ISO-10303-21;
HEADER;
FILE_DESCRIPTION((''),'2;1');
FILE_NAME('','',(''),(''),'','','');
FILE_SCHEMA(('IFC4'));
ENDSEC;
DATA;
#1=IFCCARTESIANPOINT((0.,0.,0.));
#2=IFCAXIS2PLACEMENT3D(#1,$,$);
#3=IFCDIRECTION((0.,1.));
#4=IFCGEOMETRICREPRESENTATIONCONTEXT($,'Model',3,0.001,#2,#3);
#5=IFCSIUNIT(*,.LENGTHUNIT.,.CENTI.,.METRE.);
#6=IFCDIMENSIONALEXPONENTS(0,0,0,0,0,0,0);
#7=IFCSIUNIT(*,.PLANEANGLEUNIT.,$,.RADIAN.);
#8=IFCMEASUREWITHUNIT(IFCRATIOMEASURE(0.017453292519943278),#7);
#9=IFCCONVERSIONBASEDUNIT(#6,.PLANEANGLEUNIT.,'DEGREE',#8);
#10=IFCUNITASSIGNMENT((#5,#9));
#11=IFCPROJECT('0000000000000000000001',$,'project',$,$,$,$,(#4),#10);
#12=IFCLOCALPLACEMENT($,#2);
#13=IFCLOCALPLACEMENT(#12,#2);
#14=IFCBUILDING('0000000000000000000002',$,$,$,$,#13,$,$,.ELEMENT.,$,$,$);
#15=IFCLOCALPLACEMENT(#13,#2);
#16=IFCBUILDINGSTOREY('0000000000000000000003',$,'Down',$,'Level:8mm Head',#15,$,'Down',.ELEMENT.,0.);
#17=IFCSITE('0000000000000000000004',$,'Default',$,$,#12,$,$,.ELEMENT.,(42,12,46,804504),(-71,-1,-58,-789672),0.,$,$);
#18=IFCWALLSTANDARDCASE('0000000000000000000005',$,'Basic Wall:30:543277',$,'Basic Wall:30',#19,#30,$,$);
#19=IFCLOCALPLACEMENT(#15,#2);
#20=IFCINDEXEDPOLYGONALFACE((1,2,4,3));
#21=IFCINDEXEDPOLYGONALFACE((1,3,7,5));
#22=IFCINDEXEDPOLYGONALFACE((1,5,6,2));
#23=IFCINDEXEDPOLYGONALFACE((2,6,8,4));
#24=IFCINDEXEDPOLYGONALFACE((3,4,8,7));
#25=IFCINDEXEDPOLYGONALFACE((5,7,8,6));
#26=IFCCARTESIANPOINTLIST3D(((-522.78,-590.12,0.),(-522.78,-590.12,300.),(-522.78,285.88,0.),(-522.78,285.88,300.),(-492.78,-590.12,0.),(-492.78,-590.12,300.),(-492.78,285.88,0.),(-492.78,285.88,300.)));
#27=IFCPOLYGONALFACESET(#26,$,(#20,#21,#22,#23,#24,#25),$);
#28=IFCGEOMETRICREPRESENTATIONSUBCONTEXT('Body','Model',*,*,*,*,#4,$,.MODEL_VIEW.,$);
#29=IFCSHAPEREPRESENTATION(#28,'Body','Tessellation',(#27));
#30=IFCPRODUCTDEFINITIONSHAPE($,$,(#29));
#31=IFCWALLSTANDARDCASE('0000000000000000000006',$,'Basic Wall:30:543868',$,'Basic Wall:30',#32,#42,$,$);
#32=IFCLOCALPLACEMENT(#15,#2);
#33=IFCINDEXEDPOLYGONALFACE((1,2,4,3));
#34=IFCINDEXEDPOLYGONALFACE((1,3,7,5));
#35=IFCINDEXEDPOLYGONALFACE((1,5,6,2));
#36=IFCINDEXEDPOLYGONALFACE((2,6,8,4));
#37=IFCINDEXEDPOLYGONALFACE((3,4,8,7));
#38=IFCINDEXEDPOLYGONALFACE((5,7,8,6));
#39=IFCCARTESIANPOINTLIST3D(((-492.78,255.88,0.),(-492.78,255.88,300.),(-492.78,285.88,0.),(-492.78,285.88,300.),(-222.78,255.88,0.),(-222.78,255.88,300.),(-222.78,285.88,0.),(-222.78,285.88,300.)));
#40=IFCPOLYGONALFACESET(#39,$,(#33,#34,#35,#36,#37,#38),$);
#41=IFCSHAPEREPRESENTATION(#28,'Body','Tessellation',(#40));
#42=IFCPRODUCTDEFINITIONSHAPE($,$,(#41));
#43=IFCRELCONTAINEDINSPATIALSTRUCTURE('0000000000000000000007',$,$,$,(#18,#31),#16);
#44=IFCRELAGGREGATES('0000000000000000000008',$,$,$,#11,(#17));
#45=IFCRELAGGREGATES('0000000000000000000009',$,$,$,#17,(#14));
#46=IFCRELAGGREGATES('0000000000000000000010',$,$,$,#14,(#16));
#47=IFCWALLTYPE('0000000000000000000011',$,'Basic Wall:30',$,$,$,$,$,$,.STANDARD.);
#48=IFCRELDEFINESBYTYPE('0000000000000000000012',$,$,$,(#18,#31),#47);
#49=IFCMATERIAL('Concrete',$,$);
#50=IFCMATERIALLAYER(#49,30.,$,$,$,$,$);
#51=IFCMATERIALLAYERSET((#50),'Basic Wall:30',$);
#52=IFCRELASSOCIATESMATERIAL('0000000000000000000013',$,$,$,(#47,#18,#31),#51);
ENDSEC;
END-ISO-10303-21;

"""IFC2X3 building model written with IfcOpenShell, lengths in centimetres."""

from ifc_helpers import new_model, entity, si_unit, converted_unit, direction, frame, frame_2d, origin, place, context, subcontext, project, spatial, rectangle, extrude, material, layer, layer_set, layer_usage, type_object, element, save


model = new_model("IFC2X3")

# Units and contexts
model_context = context("Model", 3, precision=0.001, world=origin(), true_north=direction((0.0, 1.0)))
body_context = subcontext(model_context, "Body", "Model", "MODEL_VIEW")
ifc_project = project(units=[si_unit("LENGTHUNIT", "METRE", prefix="CENTI"), converted_unit("PLANEANGLEUNIT", "DEGREE", entity("IfcRatioMeasure", 0.017453292519943278), si_unit("PLANEANGLEUNIT", "RADIAN"), dimensions=[0, 0, 0, 0, 0, 0, 0])], contexts=[model_context])

# Site, building, storey
site_placement = place(None, origin())
site = spatial("IfcSite", under=ifc_project, at=site_placement, Name="Default", CompositionType="ELEMENT", RefLatitude=(42, 12, 46, 804504), RefLongitude=(-71, -1, -58, -789672), RefElevation=0.0)
building_placement = place(site_placement, origin())
building = spatial("IfcBuilding", under=site, at=building_placement, CompositionType="ELEMENT")
storey_placement = place(building_placement, origin())
storey = spatial("IfcBuildingStorey", under=building, at=storey_placement, Name="Down", ObjectType="Level:8mm Head", LongName="Down", CompositionType="ELEMENT", Elevation=0.0)

# Shared definitions
ifc_material = material(Name="Concrete")

# Walls
ifc_layer_1 = layer(ifc_material, 30.0)
ifc_layer_set_1 = layer_set([ifc_layer_1], Name="Basic Wall:30")
ifc_layer_usage_1 = layer_usage(ifc_layer_set_1, "AXIS2", "POSITIVE", -15.0)
wall_type_1 = type_object("IfcWallType", Name="Basic Wall:30", PredefinedType="STANDARD", material=ifc_layer_set_1)
wall_1_placement = place(storey_placement, frame((-507.78, 285.88, 0.0), z_axis=(0.0, 0.0, 1.0), x_axis=(0.0, -1.0, 0.0)))
element("IfcWallStandardCase", 1, at=wall_1_placement, inside=storey, type_object=wall_type_1, material=ifc_layer_usage_1, Name="Basic Wall:30:543277", ObjectType="Basic Wall:30", context=body_context, shape_type="SweptSolid", body=[
    extrude(rectangle(XDim=876.0, YDim=30.0, at=frame_2d((438.0, 0.0), x_axis=(-1.0, 0.0))), origin(), (0.0, 0.0, 1.0), 300.0),
])
ifc_layer_usage_2 = layer_usage(ifc_layer_set_1, "AXIS2", "NEGATIVE", 15.0)
wall_2_placement = place(storey_placement, frame((-492.78, 270.88, 0.0)))
element("IfcWallStandardCase", 2, at=wall_2_placement, inside=storey, type_object=wall_type_1, material=ifc_layer_usage_2, Name="Basic Wall:30:543868", ObjectType="Basic Wall:30", context=body_context, shape_type="SweptSolid", body=[
    extrude(rectangle(XDim=270.0, YDim=30.0, at=frame_2d((135.0, 0.0), x_axis=(-1.0, 0.0))), origin(), (0.0, 0.0, 1.0), 300.0),
])

save(model, "model.ifc")
